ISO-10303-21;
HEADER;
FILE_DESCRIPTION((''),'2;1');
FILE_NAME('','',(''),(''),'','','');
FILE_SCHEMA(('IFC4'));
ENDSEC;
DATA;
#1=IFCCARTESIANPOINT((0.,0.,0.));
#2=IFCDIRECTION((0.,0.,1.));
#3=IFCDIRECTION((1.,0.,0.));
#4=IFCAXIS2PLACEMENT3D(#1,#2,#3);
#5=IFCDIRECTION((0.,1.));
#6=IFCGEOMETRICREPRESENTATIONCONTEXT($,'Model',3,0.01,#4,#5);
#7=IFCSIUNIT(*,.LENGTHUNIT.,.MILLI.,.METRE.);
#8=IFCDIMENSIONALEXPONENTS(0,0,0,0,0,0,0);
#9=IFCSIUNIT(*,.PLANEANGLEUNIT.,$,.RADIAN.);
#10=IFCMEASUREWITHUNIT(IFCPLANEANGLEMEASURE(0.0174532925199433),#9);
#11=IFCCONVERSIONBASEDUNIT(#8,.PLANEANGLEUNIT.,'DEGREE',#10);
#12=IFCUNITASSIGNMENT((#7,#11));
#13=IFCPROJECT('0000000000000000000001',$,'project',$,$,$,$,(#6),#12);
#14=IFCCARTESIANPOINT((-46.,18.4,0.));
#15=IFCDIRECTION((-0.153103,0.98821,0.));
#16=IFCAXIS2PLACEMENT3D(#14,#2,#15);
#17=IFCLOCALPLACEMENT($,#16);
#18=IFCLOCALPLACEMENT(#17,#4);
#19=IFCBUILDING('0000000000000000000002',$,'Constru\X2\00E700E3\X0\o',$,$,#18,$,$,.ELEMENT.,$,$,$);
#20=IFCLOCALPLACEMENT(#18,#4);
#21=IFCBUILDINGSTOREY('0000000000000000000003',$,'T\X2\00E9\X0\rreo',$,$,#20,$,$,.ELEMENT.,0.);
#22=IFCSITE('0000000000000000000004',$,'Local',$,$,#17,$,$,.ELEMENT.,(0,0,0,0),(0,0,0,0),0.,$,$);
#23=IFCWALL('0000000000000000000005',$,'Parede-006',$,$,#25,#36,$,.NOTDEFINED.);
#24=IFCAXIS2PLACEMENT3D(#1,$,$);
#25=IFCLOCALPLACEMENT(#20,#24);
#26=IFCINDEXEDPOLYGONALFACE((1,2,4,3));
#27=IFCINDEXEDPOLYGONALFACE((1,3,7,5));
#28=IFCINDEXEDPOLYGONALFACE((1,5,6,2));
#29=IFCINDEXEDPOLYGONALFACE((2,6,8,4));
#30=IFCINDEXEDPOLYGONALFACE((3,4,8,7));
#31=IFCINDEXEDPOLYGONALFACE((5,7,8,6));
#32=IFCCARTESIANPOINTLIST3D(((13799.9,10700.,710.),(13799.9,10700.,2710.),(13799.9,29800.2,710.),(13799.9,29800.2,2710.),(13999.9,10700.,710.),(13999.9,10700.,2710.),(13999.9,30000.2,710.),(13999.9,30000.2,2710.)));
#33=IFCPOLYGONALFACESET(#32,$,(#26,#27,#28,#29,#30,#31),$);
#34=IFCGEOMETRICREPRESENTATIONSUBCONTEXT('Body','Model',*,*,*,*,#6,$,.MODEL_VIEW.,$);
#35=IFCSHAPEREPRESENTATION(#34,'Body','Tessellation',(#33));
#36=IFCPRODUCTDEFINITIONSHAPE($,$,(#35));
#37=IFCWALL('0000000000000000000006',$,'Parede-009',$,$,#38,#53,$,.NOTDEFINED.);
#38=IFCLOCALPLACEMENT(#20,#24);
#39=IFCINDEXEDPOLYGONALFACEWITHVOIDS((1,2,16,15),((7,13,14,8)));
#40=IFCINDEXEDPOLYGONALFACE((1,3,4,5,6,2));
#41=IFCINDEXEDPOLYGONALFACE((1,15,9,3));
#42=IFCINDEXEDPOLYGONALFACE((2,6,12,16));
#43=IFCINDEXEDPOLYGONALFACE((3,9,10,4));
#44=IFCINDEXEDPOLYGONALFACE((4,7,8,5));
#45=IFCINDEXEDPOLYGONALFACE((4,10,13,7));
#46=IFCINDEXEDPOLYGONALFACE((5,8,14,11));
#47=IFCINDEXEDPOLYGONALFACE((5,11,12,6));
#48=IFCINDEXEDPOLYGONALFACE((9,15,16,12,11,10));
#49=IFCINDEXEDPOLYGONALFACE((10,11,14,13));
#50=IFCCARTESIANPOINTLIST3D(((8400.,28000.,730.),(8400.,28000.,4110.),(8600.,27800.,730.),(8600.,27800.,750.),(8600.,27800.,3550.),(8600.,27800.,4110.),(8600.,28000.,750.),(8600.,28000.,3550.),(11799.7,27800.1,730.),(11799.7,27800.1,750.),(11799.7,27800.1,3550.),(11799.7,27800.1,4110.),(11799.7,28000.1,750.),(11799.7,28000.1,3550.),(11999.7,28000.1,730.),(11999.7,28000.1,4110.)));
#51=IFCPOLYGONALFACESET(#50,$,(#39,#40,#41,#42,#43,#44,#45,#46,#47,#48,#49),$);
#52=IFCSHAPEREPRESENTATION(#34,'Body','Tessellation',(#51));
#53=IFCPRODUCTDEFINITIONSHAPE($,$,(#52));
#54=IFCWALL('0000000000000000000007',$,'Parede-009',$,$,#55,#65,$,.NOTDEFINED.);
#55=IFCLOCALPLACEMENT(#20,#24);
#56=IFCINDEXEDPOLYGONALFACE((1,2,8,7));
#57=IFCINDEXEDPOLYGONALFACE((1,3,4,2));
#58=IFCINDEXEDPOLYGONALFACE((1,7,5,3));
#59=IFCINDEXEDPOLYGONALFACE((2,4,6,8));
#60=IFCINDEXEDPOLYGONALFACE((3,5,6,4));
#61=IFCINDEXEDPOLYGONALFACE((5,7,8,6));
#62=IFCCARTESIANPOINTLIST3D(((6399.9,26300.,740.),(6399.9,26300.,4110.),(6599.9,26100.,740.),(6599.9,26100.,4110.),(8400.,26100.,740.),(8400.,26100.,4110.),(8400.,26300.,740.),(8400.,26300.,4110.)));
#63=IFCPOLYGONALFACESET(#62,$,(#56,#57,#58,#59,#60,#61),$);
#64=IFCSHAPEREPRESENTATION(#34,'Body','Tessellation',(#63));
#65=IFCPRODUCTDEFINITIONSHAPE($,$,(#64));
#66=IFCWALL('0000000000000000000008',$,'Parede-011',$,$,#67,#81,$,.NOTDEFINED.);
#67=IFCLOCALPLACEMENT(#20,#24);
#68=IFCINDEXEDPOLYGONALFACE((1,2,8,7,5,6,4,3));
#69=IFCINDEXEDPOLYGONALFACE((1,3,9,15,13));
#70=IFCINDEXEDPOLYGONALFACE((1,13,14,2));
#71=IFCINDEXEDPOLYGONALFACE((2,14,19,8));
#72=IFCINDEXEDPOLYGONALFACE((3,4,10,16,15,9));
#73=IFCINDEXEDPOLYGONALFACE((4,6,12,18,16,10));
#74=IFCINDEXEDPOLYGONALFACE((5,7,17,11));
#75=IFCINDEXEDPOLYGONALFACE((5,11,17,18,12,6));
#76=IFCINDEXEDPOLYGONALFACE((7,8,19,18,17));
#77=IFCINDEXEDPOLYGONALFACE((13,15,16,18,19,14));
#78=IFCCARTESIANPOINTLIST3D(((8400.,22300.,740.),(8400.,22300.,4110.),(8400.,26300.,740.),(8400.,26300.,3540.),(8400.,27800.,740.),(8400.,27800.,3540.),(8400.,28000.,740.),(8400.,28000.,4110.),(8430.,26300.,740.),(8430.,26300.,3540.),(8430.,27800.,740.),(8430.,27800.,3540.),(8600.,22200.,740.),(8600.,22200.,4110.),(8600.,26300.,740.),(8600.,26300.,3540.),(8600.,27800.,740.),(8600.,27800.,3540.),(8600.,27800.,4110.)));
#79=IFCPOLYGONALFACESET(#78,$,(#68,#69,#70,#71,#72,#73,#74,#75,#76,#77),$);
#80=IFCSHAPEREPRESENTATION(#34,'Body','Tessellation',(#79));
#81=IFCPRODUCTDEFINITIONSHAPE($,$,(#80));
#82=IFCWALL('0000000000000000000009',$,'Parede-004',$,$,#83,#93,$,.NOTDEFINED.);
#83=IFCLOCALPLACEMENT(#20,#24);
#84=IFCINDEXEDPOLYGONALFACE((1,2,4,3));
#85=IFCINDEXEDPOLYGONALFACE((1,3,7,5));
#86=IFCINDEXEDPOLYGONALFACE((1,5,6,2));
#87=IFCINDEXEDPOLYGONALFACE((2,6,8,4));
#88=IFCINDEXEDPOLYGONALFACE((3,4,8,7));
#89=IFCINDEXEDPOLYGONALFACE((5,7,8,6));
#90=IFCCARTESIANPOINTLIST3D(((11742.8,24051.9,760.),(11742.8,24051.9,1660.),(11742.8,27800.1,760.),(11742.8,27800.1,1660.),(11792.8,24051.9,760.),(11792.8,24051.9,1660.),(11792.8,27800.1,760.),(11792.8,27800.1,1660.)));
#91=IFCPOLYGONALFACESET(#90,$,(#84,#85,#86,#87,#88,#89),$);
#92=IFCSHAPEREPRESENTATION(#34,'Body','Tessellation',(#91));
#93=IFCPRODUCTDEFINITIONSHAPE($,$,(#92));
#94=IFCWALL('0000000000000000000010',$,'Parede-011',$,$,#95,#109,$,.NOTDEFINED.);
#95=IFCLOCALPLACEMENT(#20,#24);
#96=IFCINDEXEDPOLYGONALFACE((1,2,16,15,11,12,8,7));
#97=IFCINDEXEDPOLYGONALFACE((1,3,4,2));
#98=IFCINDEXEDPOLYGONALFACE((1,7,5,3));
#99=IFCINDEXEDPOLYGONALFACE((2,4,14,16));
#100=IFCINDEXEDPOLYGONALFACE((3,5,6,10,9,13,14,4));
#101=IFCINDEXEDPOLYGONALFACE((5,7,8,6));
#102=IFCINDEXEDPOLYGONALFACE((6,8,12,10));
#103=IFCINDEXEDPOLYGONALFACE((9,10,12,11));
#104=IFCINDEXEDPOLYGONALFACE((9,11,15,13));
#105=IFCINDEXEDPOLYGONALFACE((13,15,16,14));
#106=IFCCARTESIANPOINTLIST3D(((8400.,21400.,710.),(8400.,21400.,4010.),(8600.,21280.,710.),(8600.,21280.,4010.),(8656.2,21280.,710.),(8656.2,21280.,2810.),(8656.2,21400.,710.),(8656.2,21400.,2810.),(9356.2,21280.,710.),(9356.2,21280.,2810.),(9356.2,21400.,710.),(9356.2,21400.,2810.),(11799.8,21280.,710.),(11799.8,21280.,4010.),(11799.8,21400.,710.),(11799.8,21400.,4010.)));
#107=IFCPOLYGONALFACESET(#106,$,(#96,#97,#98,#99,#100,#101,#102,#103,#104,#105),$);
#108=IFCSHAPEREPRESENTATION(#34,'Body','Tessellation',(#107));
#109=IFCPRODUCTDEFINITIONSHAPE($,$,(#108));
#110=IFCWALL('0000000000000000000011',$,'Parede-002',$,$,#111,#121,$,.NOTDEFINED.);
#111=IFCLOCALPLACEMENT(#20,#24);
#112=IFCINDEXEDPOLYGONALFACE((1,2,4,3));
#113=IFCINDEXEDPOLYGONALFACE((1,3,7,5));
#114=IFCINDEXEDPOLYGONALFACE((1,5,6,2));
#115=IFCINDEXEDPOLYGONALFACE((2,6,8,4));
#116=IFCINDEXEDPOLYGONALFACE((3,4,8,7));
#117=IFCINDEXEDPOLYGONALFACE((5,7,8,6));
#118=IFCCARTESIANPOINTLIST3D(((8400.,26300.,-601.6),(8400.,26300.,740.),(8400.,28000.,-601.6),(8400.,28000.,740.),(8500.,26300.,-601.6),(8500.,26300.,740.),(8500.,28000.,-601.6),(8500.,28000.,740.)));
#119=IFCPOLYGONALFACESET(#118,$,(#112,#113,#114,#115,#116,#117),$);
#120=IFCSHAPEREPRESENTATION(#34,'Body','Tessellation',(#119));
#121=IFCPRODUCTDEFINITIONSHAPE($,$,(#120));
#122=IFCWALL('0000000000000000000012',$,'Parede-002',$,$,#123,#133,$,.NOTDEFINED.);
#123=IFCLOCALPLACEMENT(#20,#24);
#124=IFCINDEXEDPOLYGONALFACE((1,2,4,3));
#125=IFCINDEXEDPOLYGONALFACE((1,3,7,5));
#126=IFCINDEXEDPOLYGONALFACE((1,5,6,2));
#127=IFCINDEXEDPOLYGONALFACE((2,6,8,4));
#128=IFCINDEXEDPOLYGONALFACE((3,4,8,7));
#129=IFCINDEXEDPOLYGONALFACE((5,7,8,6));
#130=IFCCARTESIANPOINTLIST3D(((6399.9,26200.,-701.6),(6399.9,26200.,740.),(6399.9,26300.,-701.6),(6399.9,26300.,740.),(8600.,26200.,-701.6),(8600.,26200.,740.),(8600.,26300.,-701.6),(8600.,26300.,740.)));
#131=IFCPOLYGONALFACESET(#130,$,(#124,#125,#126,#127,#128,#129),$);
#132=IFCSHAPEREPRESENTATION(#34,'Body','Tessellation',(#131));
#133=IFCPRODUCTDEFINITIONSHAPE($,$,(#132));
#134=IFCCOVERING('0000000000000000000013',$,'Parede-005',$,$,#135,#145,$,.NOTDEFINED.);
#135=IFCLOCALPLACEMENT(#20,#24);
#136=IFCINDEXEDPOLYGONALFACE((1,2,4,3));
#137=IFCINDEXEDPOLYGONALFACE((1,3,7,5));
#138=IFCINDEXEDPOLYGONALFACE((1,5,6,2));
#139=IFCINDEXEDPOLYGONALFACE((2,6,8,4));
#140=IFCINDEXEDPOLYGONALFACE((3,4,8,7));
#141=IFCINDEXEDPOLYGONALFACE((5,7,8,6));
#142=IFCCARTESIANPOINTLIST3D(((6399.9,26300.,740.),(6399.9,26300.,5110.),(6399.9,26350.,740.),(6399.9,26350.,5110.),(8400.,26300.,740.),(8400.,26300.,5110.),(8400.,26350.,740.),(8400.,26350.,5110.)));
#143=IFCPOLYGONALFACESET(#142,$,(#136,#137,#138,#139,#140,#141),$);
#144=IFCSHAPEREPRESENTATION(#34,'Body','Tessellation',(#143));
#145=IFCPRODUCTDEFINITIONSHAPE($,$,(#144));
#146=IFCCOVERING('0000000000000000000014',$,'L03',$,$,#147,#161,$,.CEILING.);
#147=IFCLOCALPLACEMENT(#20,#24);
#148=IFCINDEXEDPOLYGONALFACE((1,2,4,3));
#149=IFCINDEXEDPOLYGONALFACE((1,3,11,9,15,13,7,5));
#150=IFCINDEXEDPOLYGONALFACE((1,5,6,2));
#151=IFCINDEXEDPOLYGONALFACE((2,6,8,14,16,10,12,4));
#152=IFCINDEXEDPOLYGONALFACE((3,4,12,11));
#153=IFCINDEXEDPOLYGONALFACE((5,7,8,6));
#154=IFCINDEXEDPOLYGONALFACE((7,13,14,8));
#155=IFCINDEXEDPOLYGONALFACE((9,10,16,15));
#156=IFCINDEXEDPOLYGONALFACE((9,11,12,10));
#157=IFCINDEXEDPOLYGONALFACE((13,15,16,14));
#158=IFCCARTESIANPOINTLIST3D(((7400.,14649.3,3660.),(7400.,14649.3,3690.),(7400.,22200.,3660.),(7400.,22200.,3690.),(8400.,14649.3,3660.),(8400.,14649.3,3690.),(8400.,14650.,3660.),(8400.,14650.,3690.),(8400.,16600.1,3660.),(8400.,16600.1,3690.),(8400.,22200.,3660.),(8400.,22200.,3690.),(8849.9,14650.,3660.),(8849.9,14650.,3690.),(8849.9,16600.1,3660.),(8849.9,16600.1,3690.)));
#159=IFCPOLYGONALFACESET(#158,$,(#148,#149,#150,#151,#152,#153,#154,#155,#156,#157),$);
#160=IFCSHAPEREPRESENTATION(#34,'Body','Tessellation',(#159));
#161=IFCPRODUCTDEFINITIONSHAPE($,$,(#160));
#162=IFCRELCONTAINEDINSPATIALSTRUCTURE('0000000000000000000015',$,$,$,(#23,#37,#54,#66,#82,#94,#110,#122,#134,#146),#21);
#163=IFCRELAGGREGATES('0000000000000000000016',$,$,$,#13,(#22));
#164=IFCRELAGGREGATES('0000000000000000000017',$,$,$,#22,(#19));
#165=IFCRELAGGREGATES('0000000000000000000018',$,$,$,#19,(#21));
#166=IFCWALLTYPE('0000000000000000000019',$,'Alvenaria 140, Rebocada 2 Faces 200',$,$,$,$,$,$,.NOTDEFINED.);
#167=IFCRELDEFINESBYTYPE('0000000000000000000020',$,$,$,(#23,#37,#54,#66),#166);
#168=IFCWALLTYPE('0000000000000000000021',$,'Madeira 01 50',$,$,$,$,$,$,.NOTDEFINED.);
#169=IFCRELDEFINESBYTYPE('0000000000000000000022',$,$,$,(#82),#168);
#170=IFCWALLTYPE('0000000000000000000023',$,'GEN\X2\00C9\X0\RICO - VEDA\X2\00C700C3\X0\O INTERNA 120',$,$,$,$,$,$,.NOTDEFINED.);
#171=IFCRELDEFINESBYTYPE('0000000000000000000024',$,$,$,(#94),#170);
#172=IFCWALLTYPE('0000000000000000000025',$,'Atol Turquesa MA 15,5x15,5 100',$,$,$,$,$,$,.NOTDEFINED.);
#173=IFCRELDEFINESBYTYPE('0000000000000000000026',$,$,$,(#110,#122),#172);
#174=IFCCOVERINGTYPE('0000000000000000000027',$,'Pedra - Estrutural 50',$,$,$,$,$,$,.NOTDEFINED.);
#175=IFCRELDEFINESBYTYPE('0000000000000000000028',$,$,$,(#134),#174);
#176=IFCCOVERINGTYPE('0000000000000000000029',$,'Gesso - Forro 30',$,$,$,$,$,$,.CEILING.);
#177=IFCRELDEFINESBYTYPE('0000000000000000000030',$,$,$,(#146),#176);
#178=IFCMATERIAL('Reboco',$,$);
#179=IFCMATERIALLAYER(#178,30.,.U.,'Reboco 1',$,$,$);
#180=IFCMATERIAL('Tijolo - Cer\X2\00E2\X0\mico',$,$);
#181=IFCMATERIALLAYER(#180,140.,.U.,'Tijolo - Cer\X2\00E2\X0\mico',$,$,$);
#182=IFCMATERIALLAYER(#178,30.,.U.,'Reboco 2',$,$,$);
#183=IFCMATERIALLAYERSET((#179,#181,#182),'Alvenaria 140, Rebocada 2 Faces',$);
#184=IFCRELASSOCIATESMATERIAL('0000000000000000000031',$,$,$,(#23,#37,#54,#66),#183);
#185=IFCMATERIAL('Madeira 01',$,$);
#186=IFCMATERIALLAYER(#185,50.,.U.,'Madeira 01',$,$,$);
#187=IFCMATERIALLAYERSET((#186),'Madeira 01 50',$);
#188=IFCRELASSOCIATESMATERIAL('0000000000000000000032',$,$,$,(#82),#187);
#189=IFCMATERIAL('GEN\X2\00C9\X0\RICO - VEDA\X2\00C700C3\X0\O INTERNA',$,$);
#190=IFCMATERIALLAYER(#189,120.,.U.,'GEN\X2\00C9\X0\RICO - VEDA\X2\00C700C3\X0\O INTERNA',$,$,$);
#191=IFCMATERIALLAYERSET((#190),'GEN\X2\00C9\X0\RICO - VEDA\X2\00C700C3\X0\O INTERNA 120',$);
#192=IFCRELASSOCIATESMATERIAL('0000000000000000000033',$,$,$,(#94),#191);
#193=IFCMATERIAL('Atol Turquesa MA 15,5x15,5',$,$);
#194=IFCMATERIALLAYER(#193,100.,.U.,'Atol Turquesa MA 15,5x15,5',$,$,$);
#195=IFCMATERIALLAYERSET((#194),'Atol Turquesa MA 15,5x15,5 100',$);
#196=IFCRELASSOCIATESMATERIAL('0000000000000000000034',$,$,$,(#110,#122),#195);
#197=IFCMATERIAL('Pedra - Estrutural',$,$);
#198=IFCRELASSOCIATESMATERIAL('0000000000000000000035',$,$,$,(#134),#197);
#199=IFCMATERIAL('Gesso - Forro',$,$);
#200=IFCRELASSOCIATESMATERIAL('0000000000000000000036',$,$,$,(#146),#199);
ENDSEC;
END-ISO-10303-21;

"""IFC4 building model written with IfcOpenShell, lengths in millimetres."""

from ifc_helpers import new_model, entity, si_unit, converted_unit, direction, frame, origin_with_axes, origin_2d_with_axis, place, context, subcontext, project, spatial, line, indexed_curve, rectangle, outline, extrude, material, layer, layer_set, layer_usage, type_object, element, save


model = new_model("IFC4")

# Units and contexts
model_context = context("Model", 3, precision=0.01, world=origin_with_axes(), true_north=direction((0.0, 1.0)))
body_context = subcontext(model_context, "Body", "Model", "MODEL_VIEW")
ifc_project = project(units=[si_unit("LENGTHUNIT", "METRE", prefix="MILLI"), converted_unit("PLANEANGLEUNIT", "DEGREE", entity("IfcPlaneAngleMeasure", 0.0174532925199433), si_unit("PLANEANGLEUNIT", "RADIAN"), dimensions=[0, 0, 0, 0, 0, 0, 0])], contexts=[model_context])

# Site, building, storey
site_placement = place(None, frame((-46.0, 18.4, 0.0), z_axis=(0.0, 0.0, 1.0), x_axis=(-0.153103, 0.98821, 0.0)))
site = spatial("IfcSite", under=ifc_project, at=site_placement, Name="Local", CompositionType="ELEMENT", RefLatitude=(0, 0, 0, 0), RefLongitude=(0, 0, 0, 0), RefElevation=0.0)
building_placement = place(site_placement, origin_with_axes())
building = spatial("IfcBuilding", under=site, at=building_placement, Name="Construção", CompositionType="ELEMENT")
storey_placement = place(building_placement, origin_with_axes())
storey = spatial("IfcBuildingStorey", under=building, at=storey_placement, Name="Térreo", CompositionType="ELEMENT", Elevation=0.0)

# Wall
ifc_material_1 = material(Name="Reboco")
ifc_layer_1 = layer(ifc_material_1, 30.0, ventilated="UNKNOWN", Name="Reboco 1")
ifc_material_2 = material(Name="Tijolo - Cerâmico")
ifc_layer_2 = layer(ifc_material_2, 140.0, ventilated="UNKNOWN", Name="Tijolo - Cerâmico")
ifc_layer_3 = layer(ifc_material_1, 30.0, ventilated="UNKNOWN", Name="Reboco 2")
ifc_layer_set_1 = layer_set([ifc_layer_1, ifc_layer_2, ifc_layer_3], Name="Alvenaria 140, Rebocada 2 Faces")
ifc_layer_usage_1 = layer_usage(ifc_layer_set_1, "AXIS2", "NEGATIVE", 0.0)
wall_type_1 = type_object("IfcWallType", Name="Alvenaria 140, Rebocada 2 Faces 200", PredefinedType="NOTDEFINED")
wall_1_placement = place(storey_placement, frame((13999.9, 30000.2, 710.0), z_axis=(0.0, 0.0, 1.0), x_axis=(0.000002, -1.0, 0.0)))
element("IfcWall", 1, at=wall_1_placement, inside=storey, type_object=wall_type_1, material=ifc_layer_usage_1, Name="Parede-006", PredefinedType="NOTDEFINED", context=body_context, shape_type="SweptSolid", body=[
    extrude(outline(indexed_curve([(200.0, -200.0), (19300.2, -200.0), (19300.2, 0.0), (0.0, 0.0)], segments=[line(1, 2, 3, 4, 1)])), origin_with_axes(), (0.0, 0.0, 1.0), 2000.0),
])

# Wall, opening
ifc_layer_usage_2 = layer_usage(ifc_layer_set_1, "AXIS2", "POSITIVE", 0.0)
wall_2_placement = place(storey_placement, frame((11999.7, 28000.1, 730.0), z_axis=(0.0, 0.0, 1.0), x_axis=(-1.0, -0.000015, 0.0)))
wall_2 = element("IfcWall", 2, at=wall_2_placement, inside=storey, type_object=wall_type_1, material=ifc_layer_usage_2, Name="Parede-009", PredefinedType="NOTDEFINED", context=body_context, shape_type="SweptSolid", body=[
    extrude(outline(indexed_curve([(0.0, 0.0), (3599.7, 0.0), (3399.7, 200.0), (200.0, 200.0)], segments=[line(1, 2, 3, 4, 1)])), origin_with_axes(), (0.0, 0.0, 1.0), 3380.0),
])
opening_1_placement = place(wall_2_placement, frame((1799.9, 0.0, 20.0), z_axis=(0.0, 0.0, 1.0), x_axis=(1.0, 0.0, 0.0)))
element("IfcOpeningElement", 3, at=opening_1_placement, cuts=wall_2, context=body_context, shape_type="SweptSolid", body=[
    extrude(rectangle(XDim=3199.7, YDim=2800.0, at=origin_2d_with_axis()), frame((0.0, 200.0, 1400.0), z_axis=(0.0, 1.0, 0.0), x_axis=(1.0, 0.0, 0.0)), (0.0, 0.0, -1.0), 600.0),
])

# Wall
ifc_layer_usage_3 = layer_usage(ifc_layer_set_1, "AXIS2", "POSITIVE", 0.0)
wall_3_placement = place(storey_placement, frame((8400.0, 26300.0, 740.0), z_axis=(0.0, 0.0, 1.0), x_axis=(-1.0, 0.0, 0.0)))
element("IfcWall", 4, at=wall_3_placement, inside=storey, type_object=wall_type_1, material=ifc_layer_usage_3, Name="Parede-009", PredefinedType="NOTDEFINED", context=body_context, shape_type="SweptSolid", body=[
    extrude(outline(indexed_curve([(0.0, 0.0), (2000.0, 0.0), (1800.0, 200.0), (0.0, 200.0)], segments=[line(1, 2, 3, 4, 1)])), origin_with_axes(), (0.0, 0.0, 1.0), 3370.0),
])

# Wall, opening
ifc_layer_usage_4 = layer_usage(ifc_layer_set_1, "AXIS2", "NEGATIVE", 0.0)
wall_4_placement = place(storey_placement, frame((8400.0, 22200.0, 740.0), z_axis=(0.0, 0.0, 1.0), x_axis=(0.0, 1.0, 0.0)))
wall_4 = element("IfcWall", 5, at=wall_4_placement, inside=storey, type_object=wall_type_1, material=ifc_layer_usage_4, Name="Parede-011", PredefinedType="NOTDEFINED", context=body_context, shape_type="SweptSolid", body=[
    extrude(outline(indexed_curve([(0.0, -200.0), (5600.0, -200.0), (5800.0, 0.0), (100.0, 0.0)], segments=[line(1, 2, 3, 4, 1)])), origin_with_axes(), (0.0, 0.0, 1.0), 3370.0),
])
opening_2_placement = place(wall_4_placement, frame((4850.0, 0.0, 0.0), z_axis=(0.0, 0.0, 1.0), x_axis=(1.0, 0.0, 0.0)))
element("IfcOpeningElement", 6, at=opening_2_placement, cuts=wall_4, context=body_context, shape_type="SweptSolid", body=[
    extrude(rectangle(XDim=1500.0, YDim=2800.0, at=origin_2d_with_axis()), frame((0.0, -30.0, 1400.0), z_axis=(0.0, -1.0, 0.0), x_axis=(1.0, 0.0, 0.0)), (0.0, 0.0, 1.0), 370.0),
    extrude(rectangle(XDim=1500.0, YDim=2800.0, at=origin_2d_with_axis()), frame((0.0, -30.0, 1400.0), z_axis=(0.0, 1.0, 0.0), x_axis=(1.0, 0.0, 0.0)), (0.0, 0.0, 1.0), 230.0),
])
ifc_material_3 = material(Name="Madeira 01")
ifc_layer_4 = layer(ifc_material_3, 50.0, ventilated="UNKNOWN", Name="Madeira 01")
ifc_layer_set_2 = layer_set([ifc_layer_4], Name="Madeira 01 50")
wall_type_2 = type_object("IfcWallType", Name="Madeira 01 50", PredefinedType="NOTDEFINED")

# Wall
ifc_layer_usage_5 = layer_usage(ifc_layer_set_2, "AXIS2", "POSITIVE", -50.0)
wall_5_placement = place(storey_placement, frame((11742.8, 24051.9, 760.0), z_axis=(0.0, 0.0, 1.0), x_axis=(0.0, 1.0, 0.0)))
element("IfcWall", 7, at=wall_5_placement, inside=storey, type_object=wall_type_2, material=ifc_layer_usage_5, Name="Parede-004", PredefinedType="NOTDEFINED", context=body_context, shape_type="SweptSolid", body=[
    extrude(outline(indexed_curve([(0.0, -50.0), (3748.2, -50.0), (3748.2, 0.0), (0.0, 0.0)], segments=[line(1, 2, 3, 4, 1)])), origin_with_axes(), (0.0, 0.0, 1.0), 900.0),
])

# Wall, opening
ifc_material_4 = material(Name="GENÉRICO - VEDAÇÃO INTERNA")
ifc_layer_5 = layer(ifc_material_4, 120.0, ventilated="UNKNOWN", Name="GENÉRICO - VEDAÇÃO INTERNA")
ifc_layer_set_3 = layer_set([ifc_layer_5], Name="GENÉRICO - VEDAÇÃO INTERNA 120")
ifc_layer_usage_6 = layer_usage(ifc_layer_set_3, "AXIS2", "POSITIVE", 0.0)
wall_type_3 = type_object("IfcWallType", Name="GENÉRICO - VEDAÇÃO INTERNA 120", PredefinedType="NOTDEFINED")
wall_6_placement = place(storey_placement, frame((11999.8, 21400.0, 710.0), z_axis=(0.0, 0.0, 1.0), x_axis=(-1.0, 0.0, 0.0)))
wall_6 = element("IfcWall", 8, at=wall_6_placement, inside=storey, type_object=wall_type_3, material=ifc_layer_usage_6, Name="Parede-011", PredefinedType="NOTDEFINED", context=body_context, shape_type="SweptSolid", body=[
    extrude(outline(indexed_curve([(200.0, 0.0), (3599.8, 0.0), (3399.8, 120.0), (200.0, 120.0)], segments=[line(1, 2, 3, 4, 1)])), origin_with_axes(), (0.0, 0.0, 1.0), 3300.0),
])
opening_3_placement = place(wall_6_placement, frame((2993.6, 0.0, 0.0), z_axis=(0.0, 0.0, 1.0), x_axis=(1.0, 0.0, 0.0)))
element("IfcOpeningElement", 9, at=opening_3_placement, cuts=wall_6, context=body_context, shape_type="SweptSolid", body=[
    extrude(rectangle(XDim=700.0, YDim=2100.0, at=origin_2d_with_axis()), frame((0.0, 120.0, 1050.0), z_axis=(0.0, -1.0, 0.0), x_axis=(1.0, 0.0, 0.0)), (0.0, 0.0, 1.0), 360.0),
])

# Walls
ifc_material_5 = material(Name="Atol Turquesa MA 15,5x15,5")
ifc_layer_6 = layer(ifc_material_5, 100.0, ventilated="UNKNOWN", Name="Atol Turquesa MA 15,5x15,5")
ifc_layer_set_4 = layer_set([ifc_layer_6], Name="Atol Turquesa MA 15,5x15,5 100")
ifc_layer_usage_7 = layer_usage(ifc_layer_set_4, "AXIS2", "NEGATIVE", 0.0)
wall_type_4 = type_object("IfcWallType", Name="Atol Turquesa MA 15,5x15,5 100", PredefinedType="NOTDEFINED")
wall_7_placement = place(storey_placement, frame((8500.0, 28000.0, -601.6), z_axis=(0.0, 0.0, 1.0), x_axis=(0.0, -1.0, 0.0)))
element("IfcWall", 10, at=wall_7_placement, inside=storey, type_object=wall_type_4, material=ifc_layer_usage_7, Name="Parede-002", PredefinedType="NOTDEFINED", context=body_context, shape_type="SweptSolid", body=[
    extrude(outline(indexed_curve([(0.0, -100.0), (1700.0, -100.0), (1700.0, 0.0), (0.0, 0.0)], segments=[line(1, 2, 3, 4, 1)])), origin_with_axes(), (0.0, 0.0, 1.0), 1341.6),
])
ifc_layer_usage_8 = layer_usage(ifc_layer_set_4, "AXIS2", "NEGATIVE", 0.0)
wall_8_placement = place(storey_placement, frame((8600.0, 26200.0, -701.6), z_axis=(0.0, 0.0, 1.0), x_axis=(-1.0, 0.0, 0.0)))
element("IfcWall", 11, at=wall_8_placement, inside=storey, type_object=wall_type_4, material=ifc_layer_usage_8, Name="Parede-002", PredefinedType="NOTDEFINED", context=body_context, shape_type="SweptSolid", body=[
    extrude(outline(indexed_curve([(0.0, -100.0), (2200.0, -100.0), (2200.0, 0.0), (0.0, 0.0)], segments=[line(1, 2, 3, 4, 1)])), origin_with_axes(), (0.0, 0.0, 1.0), 1441.6),
])

# Coverings
ifc_material_6 = material(Name="Pedra - Estrutural")
covering_type_1 = type_object("IfcCoveringType", Name="Pedra - Estrutural 50", PredefinedType="NOTDEFINED")
covering_1_placement = place(storey_placement, frame((8400.0, 26300.0, 740.0), z_axis=(0.0, 0.0, 1.0), x_axis=(-1.0, 0.0, 0.0)))
element("IfcCovering", 12, at=covering_1_placement, inside=storey, type_object=covering_type_1, material=ifc_material_6, Name="Parede-005", PredefinedType="NOTDEFINED", context=body_context, shape_type="SweptSolid", body=[
    extrude(outline(indexed_curve([(0.0, -50.0), (2000.0, -50.0), (2000.0, 0.0), (0.0, 0.0)], segments=[line(1, 2, 3, 4, 1)])), origin_with_axes(), (0.0, 0.0, 1.0), 4370.0),
])
ifc_material_7 = material(Name="Gesso - Forro")
covering_type_2 = type_object("IfcCoveringType", Name="Gesso - Forro 30", PredefinedType="CEILING")
covering_2_placement = place(storey_placement, frame((7400.0, 22200.0, 3690.0), z_axis=(0.0, 0.0, 1.0), x_axis=(1.0, 0.0, 0.0)))
element("IfcCovering", 13, at=covering_2_placement, inside=storey, type_object=covering_type_2, material=ifc_material_7, Name="L03", PredefinedType="CEILING", context=body_context, shape_type="SweptSolid", body=[
    extrude(outline(indexed_curve([(0.0, 0.0), (0.0, -7550.8), (1000.0, -7550.8), (1000.0, -7550.0), (1450.0, -7550.0), (1450.0, -5600.0), (1000.0, -5600.0), (1000.0, 0.0)], segments=[line(1, 2, 3, 4, 5, 6, 7, 8, 1)])), frame((0.0, 0.0, -30.0), z_axis=(0.0, 0.0, 1.0), x_axis=(1.0, 0.0, 0.0)), (0.0, 0.0, 1.0), 30.0),
])

save(model, "model.ifc")
